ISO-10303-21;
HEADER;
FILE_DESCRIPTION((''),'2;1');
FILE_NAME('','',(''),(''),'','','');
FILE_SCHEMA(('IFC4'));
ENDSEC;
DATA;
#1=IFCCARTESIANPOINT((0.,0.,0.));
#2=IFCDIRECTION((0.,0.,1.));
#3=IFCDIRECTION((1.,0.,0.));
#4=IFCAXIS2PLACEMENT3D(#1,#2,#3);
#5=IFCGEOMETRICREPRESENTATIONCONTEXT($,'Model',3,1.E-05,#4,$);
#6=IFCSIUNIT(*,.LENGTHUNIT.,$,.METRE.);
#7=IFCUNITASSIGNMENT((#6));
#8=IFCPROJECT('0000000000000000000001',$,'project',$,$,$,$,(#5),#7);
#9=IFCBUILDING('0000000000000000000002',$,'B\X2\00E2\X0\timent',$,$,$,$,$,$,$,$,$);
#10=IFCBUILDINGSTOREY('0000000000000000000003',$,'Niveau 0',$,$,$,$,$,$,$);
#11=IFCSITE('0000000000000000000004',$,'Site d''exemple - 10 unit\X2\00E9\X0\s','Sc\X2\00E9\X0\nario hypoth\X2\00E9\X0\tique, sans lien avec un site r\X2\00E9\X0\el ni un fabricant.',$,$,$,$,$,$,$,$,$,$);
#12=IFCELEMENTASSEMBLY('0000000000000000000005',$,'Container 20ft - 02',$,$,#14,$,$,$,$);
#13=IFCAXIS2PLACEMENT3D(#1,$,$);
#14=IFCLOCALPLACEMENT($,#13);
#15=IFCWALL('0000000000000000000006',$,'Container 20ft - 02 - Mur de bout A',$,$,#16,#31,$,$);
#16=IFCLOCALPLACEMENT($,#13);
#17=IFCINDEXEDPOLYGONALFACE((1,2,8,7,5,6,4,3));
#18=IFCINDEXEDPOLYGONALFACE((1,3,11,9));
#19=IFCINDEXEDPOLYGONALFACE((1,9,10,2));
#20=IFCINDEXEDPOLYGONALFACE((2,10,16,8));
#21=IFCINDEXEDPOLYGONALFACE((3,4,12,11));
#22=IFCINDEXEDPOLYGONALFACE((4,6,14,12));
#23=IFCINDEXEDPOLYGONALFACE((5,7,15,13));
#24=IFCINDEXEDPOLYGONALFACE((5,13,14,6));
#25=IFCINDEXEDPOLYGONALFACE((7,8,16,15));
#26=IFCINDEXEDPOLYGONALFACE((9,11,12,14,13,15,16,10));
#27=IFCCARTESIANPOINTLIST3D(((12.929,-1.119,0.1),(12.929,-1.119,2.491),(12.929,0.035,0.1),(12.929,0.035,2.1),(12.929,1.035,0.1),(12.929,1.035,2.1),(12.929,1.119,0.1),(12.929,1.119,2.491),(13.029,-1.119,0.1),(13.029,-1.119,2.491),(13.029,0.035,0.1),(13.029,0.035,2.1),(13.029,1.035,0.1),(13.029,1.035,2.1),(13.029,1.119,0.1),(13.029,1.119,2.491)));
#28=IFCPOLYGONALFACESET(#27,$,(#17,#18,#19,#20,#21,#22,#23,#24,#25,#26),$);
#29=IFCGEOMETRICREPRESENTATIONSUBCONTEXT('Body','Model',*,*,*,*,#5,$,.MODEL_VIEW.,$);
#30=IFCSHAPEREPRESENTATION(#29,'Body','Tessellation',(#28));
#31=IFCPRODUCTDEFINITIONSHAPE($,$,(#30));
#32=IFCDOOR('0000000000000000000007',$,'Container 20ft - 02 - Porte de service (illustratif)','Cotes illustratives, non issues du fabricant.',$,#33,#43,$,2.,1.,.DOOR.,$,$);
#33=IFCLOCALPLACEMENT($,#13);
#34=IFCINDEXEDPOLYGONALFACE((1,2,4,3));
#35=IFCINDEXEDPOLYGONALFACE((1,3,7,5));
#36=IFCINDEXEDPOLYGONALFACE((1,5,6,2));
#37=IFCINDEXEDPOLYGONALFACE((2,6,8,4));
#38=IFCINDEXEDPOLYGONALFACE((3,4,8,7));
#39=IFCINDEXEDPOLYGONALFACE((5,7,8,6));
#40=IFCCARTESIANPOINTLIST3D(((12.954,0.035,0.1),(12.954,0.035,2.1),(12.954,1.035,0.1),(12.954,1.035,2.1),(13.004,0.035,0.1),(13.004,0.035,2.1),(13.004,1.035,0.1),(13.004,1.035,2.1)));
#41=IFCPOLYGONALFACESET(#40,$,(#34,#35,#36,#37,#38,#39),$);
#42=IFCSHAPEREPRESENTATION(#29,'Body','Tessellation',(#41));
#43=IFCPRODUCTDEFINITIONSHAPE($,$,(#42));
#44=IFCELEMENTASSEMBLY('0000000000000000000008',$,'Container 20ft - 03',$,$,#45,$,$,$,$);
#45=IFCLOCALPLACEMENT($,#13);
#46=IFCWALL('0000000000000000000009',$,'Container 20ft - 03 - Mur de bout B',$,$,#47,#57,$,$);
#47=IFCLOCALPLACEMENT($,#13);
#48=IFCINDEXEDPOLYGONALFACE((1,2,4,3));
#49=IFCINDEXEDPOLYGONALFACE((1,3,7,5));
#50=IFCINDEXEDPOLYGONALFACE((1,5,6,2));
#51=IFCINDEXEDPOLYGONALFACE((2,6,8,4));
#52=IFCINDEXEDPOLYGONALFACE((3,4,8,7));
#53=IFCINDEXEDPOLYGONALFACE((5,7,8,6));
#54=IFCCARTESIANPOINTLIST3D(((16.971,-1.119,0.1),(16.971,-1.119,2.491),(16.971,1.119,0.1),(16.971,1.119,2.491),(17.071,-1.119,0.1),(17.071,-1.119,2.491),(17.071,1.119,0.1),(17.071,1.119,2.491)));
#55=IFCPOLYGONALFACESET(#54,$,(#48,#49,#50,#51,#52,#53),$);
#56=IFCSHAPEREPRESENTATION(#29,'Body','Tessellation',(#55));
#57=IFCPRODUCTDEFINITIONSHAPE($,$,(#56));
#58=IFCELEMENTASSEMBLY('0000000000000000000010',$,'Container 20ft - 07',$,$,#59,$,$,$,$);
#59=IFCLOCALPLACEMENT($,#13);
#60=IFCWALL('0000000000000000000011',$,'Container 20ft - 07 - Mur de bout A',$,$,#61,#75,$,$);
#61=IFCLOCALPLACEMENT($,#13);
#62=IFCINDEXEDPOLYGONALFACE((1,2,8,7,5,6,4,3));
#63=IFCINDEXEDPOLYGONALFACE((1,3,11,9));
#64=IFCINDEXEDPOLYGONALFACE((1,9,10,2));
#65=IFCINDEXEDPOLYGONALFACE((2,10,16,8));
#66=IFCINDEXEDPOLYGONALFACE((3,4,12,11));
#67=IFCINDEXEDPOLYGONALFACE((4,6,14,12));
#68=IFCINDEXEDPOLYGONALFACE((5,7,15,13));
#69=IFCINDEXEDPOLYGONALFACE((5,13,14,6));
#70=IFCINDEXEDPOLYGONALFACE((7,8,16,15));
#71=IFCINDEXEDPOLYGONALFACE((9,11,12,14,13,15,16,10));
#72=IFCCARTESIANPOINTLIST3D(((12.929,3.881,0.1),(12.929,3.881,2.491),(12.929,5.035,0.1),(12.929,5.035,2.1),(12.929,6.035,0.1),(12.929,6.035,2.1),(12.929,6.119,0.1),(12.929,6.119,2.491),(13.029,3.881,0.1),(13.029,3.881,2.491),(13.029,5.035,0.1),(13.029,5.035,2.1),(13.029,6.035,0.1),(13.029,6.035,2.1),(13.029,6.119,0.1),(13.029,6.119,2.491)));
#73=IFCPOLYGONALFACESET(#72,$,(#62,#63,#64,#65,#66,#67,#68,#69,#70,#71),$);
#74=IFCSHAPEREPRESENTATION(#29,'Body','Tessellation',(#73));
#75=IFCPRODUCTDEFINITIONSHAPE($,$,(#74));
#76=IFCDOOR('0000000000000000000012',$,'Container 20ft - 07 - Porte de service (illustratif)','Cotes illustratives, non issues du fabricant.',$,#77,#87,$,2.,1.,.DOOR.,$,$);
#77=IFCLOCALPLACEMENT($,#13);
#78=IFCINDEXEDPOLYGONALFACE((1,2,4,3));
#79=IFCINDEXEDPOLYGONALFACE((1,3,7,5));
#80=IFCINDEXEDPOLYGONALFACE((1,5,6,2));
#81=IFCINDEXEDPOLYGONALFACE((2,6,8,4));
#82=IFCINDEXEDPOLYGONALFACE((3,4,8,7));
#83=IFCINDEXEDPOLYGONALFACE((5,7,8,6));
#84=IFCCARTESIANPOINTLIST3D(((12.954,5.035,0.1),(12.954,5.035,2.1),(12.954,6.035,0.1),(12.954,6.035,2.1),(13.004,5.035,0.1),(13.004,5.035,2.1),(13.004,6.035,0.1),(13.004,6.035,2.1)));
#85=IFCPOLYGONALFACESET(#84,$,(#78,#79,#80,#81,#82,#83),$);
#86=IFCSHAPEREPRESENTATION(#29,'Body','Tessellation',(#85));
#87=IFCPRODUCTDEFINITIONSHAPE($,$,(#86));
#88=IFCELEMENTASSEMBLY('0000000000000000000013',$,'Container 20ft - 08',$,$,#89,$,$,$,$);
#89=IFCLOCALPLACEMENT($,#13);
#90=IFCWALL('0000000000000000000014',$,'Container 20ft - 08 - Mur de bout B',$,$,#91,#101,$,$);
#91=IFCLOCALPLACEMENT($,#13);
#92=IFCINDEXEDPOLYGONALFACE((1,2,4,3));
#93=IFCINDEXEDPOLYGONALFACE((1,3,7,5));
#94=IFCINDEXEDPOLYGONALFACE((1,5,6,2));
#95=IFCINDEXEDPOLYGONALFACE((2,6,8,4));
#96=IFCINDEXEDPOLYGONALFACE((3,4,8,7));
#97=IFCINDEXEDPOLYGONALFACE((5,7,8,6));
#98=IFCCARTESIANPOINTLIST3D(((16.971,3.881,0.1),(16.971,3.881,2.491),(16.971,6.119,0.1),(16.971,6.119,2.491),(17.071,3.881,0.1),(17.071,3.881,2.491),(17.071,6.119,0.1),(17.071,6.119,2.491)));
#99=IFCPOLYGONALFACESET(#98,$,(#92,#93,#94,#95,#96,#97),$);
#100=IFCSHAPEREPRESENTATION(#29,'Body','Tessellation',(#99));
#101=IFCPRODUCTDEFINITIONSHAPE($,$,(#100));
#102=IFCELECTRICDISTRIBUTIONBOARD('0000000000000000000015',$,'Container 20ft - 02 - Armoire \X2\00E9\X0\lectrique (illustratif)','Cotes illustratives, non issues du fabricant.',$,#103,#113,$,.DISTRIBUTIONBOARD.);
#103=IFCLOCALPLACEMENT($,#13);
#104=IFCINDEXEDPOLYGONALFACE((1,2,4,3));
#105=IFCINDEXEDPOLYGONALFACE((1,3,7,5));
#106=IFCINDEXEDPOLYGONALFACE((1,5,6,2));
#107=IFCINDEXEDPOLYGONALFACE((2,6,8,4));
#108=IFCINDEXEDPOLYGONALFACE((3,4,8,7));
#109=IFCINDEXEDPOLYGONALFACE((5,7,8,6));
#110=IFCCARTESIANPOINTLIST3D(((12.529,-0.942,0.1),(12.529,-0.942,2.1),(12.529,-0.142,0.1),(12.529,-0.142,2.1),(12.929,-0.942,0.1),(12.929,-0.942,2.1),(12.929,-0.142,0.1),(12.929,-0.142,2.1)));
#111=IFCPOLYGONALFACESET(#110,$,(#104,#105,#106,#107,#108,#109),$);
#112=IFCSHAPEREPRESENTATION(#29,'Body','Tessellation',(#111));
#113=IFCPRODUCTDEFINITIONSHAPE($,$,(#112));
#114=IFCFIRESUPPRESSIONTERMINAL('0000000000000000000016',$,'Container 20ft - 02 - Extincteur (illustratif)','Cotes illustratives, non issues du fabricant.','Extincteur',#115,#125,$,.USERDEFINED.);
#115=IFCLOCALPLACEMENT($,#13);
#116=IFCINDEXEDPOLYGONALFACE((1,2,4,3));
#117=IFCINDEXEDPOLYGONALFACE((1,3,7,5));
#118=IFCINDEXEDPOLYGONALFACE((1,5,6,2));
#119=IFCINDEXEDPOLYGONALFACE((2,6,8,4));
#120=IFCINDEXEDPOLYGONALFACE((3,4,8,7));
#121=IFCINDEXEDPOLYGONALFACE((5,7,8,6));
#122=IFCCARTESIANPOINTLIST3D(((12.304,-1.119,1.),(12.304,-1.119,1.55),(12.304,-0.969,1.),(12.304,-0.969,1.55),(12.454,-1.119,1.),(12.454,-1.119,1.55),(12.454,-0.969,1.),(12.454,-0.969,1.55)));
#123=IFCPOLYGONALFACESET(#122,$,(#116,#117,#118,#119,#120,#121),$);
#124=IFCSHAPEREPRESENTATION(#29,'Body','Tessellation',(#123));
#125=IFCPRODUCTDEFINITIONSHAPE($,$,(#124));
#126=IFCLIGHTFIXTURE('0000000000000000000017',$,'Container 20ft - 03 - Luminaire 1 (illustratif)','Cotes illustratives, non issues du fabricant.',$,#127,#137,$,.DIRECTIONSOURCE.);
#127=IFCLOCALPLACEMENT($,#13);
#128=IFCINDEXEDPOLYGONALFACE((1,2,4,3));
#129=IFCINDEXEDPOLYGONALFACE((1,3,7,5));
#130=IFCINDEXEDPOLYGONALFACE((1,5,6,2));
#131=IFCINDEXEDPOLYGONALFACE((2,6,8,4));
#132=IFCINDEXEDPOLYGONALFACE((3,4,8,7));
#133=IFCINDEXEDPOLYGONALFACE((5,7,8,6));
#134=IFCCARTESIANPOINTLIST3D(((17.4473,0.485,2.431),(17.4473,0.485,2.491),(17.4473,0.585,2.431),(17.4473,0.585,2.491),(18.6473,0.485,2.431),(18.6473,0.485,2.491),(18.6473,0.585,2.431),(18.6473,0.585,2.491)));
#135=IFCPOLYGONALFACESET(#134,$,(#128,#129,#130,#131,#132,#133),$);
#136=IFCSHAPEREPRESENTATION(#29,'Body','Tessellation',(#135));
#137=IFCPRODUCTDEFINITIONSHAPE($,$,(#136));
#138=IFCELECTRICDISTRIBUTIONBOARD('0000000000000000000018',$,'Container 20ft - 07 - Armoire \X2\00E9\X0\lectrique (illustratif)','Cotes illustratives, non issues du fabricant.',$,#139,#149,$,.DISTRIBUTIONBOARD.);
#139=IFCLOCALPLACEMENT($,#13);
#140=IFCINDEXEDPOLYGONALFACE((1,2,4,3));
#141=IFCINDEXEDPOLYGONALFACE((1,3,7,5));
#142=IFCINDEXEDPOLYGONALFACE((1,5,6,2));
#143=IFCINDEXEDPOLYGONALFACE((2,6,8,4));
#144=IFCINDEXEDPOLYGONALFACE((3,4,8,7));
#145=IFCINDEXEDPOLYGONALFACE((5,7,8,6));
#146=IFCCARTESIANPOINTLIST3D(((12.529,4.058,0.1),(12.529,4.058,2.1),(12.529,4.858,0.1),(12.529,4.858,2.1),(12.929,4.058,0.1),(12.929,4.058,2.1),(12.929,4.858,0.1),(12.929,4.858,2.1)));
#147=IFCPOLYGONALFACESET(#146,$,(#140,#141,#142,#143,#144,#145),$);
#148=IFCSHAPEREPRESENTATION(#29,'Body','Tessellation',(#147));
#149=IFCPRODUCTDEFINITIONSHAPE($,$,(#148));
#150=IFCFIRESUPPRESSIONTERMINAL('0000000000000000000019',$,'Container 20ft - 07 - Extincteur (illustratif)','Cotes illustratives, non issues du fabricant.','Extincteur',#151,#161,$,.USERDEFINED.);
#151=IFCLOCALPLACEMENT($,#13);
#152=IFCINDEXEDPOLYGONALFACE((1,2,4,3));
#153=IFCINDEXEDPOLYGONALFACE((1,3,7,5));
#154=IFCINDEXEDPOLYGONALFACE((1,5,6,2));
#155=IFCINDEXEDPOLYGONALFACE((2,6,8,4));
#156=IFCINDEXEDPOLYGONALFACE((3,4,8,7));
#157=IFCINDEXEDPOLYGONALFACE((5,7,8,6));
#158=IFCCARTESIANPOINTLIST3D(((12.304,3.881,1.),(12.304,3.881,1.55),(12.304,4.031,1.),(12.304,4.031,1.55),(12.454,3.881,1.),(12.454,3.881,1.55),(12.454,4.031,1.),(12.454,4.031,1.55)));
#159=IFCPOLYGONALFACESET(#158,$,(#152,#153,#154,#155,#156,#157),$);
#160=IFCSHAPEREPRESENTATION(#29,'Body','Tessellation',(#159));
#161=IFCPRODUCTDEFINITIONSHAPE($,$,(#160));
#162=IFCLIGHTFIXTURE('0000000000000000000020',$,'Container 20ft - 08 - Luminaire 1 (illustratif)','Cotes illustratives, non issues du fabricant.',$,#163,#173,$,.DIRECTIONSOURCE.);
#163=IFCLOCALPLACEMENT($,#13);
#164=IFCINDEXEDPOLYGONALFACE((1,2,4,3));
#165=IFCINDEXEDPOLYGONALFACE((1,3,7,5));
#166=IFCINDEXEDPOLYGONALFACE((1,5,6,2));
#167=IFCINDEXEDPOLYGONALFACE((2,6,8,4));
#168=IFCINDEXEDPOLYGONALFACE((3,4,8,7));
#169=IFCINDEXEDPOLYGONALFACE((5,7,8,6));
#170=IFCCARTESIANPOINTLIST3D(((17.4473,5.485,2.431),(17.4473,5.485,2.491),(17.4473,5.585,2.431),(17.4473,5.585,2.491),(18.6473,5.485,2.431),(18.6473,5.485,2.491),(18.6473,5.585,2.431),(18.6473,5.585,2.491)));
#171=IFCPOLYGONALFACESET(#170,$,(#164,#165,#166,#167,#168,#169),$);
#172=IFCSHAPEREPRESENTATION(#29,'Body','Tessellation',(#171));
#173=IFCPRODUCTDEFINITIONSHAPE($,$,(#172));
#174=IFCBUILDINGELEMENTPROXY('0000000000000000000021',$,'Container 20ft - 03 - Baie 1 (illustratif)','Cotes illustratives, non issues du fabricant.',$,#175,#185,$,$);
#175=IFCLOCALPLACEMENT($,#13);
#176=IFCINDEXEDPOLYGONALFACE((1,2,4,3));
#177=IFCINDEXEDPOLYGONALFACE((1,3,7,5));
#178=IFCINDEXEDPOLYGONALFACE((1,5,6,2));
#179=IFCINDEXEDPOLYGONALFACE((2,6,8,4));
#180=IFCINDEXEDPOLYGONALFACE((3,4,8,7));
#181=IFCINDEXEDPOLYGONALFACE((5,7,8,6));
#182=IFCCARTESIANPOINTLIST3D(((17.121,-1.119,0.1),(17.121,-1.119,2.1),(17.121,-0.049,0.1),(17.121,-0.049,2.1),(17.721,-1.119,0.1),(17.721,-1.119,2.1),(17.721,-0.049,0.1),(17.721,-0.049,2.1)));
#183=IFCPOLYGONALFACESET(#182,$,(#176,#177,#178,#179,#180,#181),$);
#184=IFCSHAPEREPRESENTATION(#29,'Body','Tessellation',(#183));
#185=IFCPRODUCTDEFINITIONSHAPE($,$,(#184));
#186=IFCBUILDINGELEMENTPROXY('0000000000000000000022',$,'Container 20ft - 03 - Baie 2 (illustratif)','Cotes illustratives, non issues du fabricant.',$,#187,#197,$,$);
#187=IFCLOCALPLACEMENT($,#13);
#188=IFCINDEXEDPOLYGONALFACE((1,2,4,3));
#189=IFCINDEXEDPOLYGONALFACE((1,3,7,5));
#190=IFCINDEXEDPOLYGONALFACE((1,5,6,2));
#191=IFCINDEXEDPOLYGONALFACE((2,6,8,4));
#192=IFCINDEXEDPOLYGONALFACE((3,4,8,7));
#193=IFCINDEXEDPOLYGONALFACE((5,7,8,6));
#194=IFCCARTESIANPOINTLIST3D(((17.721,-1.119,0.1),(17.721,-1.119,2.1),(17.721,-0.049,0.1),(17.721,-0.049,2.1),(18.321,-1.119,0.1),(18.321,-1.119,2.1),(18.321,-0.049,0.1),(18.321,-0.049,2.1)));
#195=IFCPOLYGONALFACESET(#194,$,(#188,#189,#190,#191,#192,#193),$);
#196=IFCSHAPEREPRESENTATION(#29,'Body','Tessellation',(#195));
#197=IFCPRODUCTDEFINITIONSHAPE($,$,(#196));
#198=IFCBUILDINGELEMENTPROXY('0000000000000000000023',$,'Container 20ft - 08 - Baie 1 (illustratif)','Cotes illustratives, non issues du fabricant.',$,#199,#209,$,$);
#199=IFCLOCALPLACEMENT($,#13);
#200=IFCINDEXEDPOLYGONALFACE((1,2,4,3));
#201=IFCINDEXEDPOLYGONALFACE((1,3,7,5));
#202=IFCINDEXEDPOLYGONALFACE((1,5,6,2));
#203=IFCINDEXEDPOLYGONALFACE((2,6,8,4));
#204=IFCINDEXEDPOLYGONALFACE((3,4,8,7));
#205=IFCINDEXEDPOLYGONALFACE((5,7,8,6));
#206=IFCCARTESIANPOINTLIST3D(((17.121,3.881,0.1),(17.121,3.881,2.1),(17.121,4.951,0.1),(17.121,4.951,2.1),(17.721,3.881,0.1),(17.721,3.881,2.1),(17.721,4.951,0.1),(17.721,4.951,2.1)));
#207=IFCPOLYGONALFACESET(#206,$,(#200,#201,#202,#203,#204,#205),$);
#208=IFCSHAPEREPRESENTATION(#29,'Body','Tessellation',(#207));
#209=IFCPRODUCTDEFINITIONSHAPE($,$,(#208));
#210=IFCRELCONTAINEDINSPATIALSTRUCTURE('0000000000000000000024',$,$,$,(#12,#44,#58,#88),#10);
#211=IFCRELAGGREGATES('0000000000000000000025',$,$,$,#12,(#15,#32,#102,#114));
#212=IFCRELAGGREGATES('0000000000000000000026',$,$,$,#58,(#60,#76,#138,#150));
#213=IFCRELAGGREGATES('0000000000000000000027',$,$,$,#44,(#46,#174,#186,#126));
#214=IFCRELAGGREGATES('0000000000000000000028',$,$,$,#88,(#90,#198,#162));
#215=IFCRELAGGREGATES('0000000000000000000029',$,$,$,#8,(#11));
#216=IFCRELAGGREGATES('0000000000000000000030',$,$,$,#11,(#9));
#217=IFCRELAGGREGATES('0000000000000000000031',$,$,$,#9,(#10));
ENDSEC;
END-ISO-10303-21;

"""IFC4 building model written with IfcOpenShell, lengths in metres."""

from ifc_helpers import new_model, si_unit, frame, origin_with_axes, place, context, subcontext, project, spatial, rectangle, extrude, element, fill, aggregate, save


model = new_model("IFC4")

# Units and contexts
model_context = context("Model", 3, precision=1e-05, world=origin_with_axes())
body_context = subcontext(model_context, "Body", "Model", "MODEL_VIEW")
ifc_project = project(units=[si_unit("LENGTHUNIT", "METRE")], contexts=[model_context])

# Site, building, storey
site = spatial("IfcSite", under=ifc_project, Name="Site d'exemple - 10 unités", Description="Scénario hypothétique, sans lien avec un site réel ni un fabricant.")
building = spatial("IfcBuilding", under=site, Name="Bâtiment")
storey = spatial("IfcBuildingStorey", under=building, Name="Niveau 0")

# Element assembly, wall, opening, door
assembly_1 = element("IfcElementAssembly", 1, inside=storey, Name="Container 20ft - 02")
wall_1_placement = place(None, frame((12.979, 0.0, 0.1), z_axis=(0.0, 0.0, 1.0), x_axis=(1.0, 0.0, 0.0)))
wall_1 = element("IfcWall", 2, at=wall_1_placement, Name="Container 20ft - 02 - Mur de bout A", context=body_context, shape_type="SweptSolid", body=[
    extrude(rectangle(XDim=0.1, YDim=2.238), origin_with_axes(), (0.0, 0.0, 1.0), 2.391),
])
opening_1_placement = place(None, frame((12.979, 0.535, 0.1), z_axis=(0.0, 0.0, 1.0), x_axis=(1.0, 0.0, 0.0)))
opening_1 = element("IfcOpeningElement", 3, at=opening_1_placement, cuts=wall_1, PredefinedType="OPENING", context=body_context, shape_type="SweptSolid", body=[
    extrude(rectangle(XDim=0.2, YDim=1.0), origin_with_axes(), (0.0, 0.0, 1.0), 2.0),
])
door_1_placement = place(None, frame((12.979, 0.535, 0.1), z_axis=(0.0, 0.0, 1.0), x_axis=(1.0, 0.0, 0.0)))
door_1 = element("IfcDoor", 4, at=door_1_placement, Name="Container 20ft - 02 - Porte de service (illustratif)", Description="Cotes illustratives, non issues du fabricant.", OverallHeight=2.0, OverallWidth=1.0, PredefinedType="DOOR", context=body_context, shape_type="SweptSolid", body=[
    extrude(rectangle(XDim=0.05, YDim=1.0), origin_with_axes(), (0.0, 0.0, 1.0), 2.0),
])
fill(opening_1, door_1)

# Element assembly, wall
assembly_2 = element("IfcElementAssembly", 5, inside=storey, Name="Container 20ft - 03")
wall_2_placement = place(None, frame((17.021, 0.0, 0.1), z_axis=(0.0, 0.0, 1.0), x_axis=(1.0, 0.0, 0.0)))
wall_2 = element("IfcWall", 6, at=wall_2_placement, Name="Container 20ft - 03 - Mur de bout B", context=body_context, shape_type="SweptSolid", body=[
    extrude(rectangle(XDim=0.1, YDim=2.238), origin_with_axes(), (0.0, 0.0, 1.0), 2.391),
])

# Element assembly, wall, opening, door
assembly_3 = element("IfcElementAssembly", 7, inside=storey, Name="Container 20ft - 07")
wall_3_placement = place(None, frame((12.979, 5.0, 0.1), z_axis=(0.0, 0.0, 1.0), x_axis=(1.0, 0.0, 0.0)))
wall_3 = element("IfcWall", 8, at=wall_3_placement, Name="Container 20ft - 07 - Mur de bout A", context=body_context, shape_type="SweptSolid", body=[
    extrude(rectangle(XDim=0.1, YDim=2.238), origin_with_axes(), (0.0, 0.0, 1.0), 2.391),
])
opening_2_placement = place(None, frame((12.979, 5.535, 0.1), z_axis=(0.0, 0.0, 1.0), x_axis=(1.0, 0.0, 0.0)))
opening_2 = element("IfcOpeningElement", 9, at=opening_2_placement, cuts=wall_3, PredefinedType="OPENING", context=body_context, shape_type="SweptSolid", body=[
    extrude(rectangle(XDim=0.2, YDim=1.0), origin_with_axes(), (0.0, 0.0, 1.0), 2.0),
])
door_2_placement = place(None, frame((12.979, 5.535, 0.1), z_axis=(0.0, 0.0, 1.0), x_axis=(1.0, 0.0, 0.0)))
door_2 = element("IfcDoor", 10, at=door_2_placement, Name="Container 20ft - 07 - Porte de service (illustratif)", Description="Cotes illustratives, non issues du fabricant.", OverallHeight=2.0, OverallWidth=1.0, PredefinedType="DOOR", context=body_context, shape_type="SweptSolid", body=[
    extrude(rectangle(XDim=0.05, YDim=1.0), origin_with_axes(), (0.0, 0.0, 1.0), 2.0),
])
fill(opening_2, door_2)

# Element assembly, wall
assembly_4 = element("IfcElementAssembly", 11, inside=storey, Name="Container 20ft - 08")
wall_4_placement = place(None, frame((17.021, 5.0, 0.1), z_axis=(0.0, 0.0, 1.0), x_axis=(1.0, 0.0, 0.0)))
wall_4 = element("IfcWall", 12, at=wall_4_placement, Name="Container 20ft - 08 - Mur de bout B", context=body_context, shape_type="SweptSolid", body=[
    extrude(rectangle(XDim=0.1, YDim=2.238), origin_with_axes(), (0.0, 0.0, 1.0), 2.391),
])

# Electric distribution board
electric_distribution_board_1_placement = place(None, frame((12.729, -0.542, 0.1), z_axis=(0.0, 0.0, 1.0), x_axis=(1.0, 0.0, 0.0)))
electric_distribution_board_1 = element("IfcElectricDistributionBoard", 13, at=electric_distribution_board_1_placement, Name="Container 20ft - 02 - Armoire électrique (illustratif)", Description="Cotes illustratives, non issues du fabricant.", PredefinedType="DISTRIBUTIONBOARD", context=body_context, shape_type="SweptSolid", body=[
    extrude(rectangle(XDim=0.4, YDim=0.8), origin_with_axes(), (0.0, 0.0, 1.0), 2.0),
])

# Fire suppression terminal
fire_suppression_terminal_1_placement = place(None, frame((12.379, -1.044, 1.0), z_axis=(0.0, 0.0, 1.0), x_axis=(1.0, 0.0, 0.0)))
fire_suppression_terminal_1 = element("IfcFireSuppressionTerminal", 14, at=fire_suppression_terminal_1_placement, Name="Container 20ft - 02 - Extincteur (illustratif)", Description="Cotes illustratives, non issues du fabricant.", ObjectType="Extincteur", PredefinedType="USERDEFINED", context=body_context, shape_type="SweptSolid", body=[
    extrude(rectangle(XDim=0.15, YDim=0.15), origin_with_axes(), (0.0, 0.0, 1.0), 0.55),
])
aggregate(assembly_1, [wall_1, door_1, electric_distribution_board_1, fire_suppression_terminal_1])

# Light fixture
light_fixture_1_placement = place(None, frame((18.0473, 0.535, 2.431), z_axis=(0.0, 0.0, 1.0), x_axis=(1.0, 0.0, 0.0)))
light_fixture_1 = element("IfcLightFixture", 15, at=light_fixture_1_placement, Name="Container 20ft - 03 - Luminaire 1 (illustratif)", Description="Cotes illustratives, non issues du fabricant.", PredefinedType="DIRECTIONSOURCE", context=body_context, shape_type="SweptSolid", body=[
    extrude(rectangle(XDim=1.2, YDim=0.1), origin_with_axes(), (0.0, 0.0, 1.0), 0.06),
])

# Electric distribution board
electric_distribution_board_2_placement = place(None, frame((12.729, 4.458, 0.1), z_axis=(0.0, 0.0, 1.0), x_axis=(1.0, 0.0, 0.0)))
electric_distribution_board_2 = element("IfcElectricDistributionBoard", 16, at=electric_distribution_board_2_placement, Name="Container 20ft - 07 - Armoire électrique (illustratif)", Description="Cotes illustratives, non issues du fabricant.", PredefinedType="DISTRIBUTIONBOARD", context=body_context, shape_type="SweptSolid", body=[
    extrude(rectangle(XDim=0.4, YDim=0.8), origin_with_axes(), (0.0, 0.0, 1.0), 2.0),
])

# Fire suppression terminal
fire_suppression_terminal_2_placement = place(None, frame((12.379, 3.956, 1.0), z_axis=(0.0, 0.0, 1.0), x_axis=(1.0, 0.0, 0.0)))
fire_suppression_terminal_2 = element("IfcFireSuppressionTerminal", 17, at=fire_suppression_terminal_2_placement, Name="Container 20ft - 07 - Extincteur (illustratif)", Description="Cotes illustratives, non issues du fabricant.", ObjectType="Extincteur", PredefinedType="USERDEFINED", context=body_context, shape_type="SweptSolid", body=[
    extrude(rectangle(XDim=0.15, YDim=0.15), origin_with_axes(), (0.0, 0.0, 1.0), 0.55),
])
aggregate(assembly_3, [wall_3, door_2, electric_distribution_board_2, fire_suppression_terminal_2])

# Light fixture
light_fixture_2_placement = place(None, frame((18.0473, 5.535, 2.431), z_axis=(0.0, 0.0, 1.0), x_axis=(1.0, 0.0, 0.0)))
light_fixture_2 = element("IfcLightFixture", 18, at=light_fixture_2_placement, Name="Container 20ft - 08 - Luminaire 1 (illustratif)", Description="Cotes illustratives, non issues du fabricant.", PredefinedType="DIRECTIONSOURCE", context=body_context, shape_type="SweptSolid", body=[
    extrude(rectangle(XDim=1.2, YDim=0.1), origin_with_axes(), (0.0, 0.0, 1.0), 0.06),
])

# Building element proxies
proxy_1_placement = place(None, frame((17.421, -0.584, 0.1), z_axis=(0.0, 0.0, 1.0), x_axis=(1.0, 0.0, 0.0)))
proxy_1 = element("IfcBuildingElementProxy", 19, at=proxy_1_placement, Name="Container 20ft - 03 - Baie 1 (illustratif)", Description="Cotes illustratives, non issues du fabricant.", context=body_context, shape_type="SweptSolid", body=[
    extrude(rectangle(XDim=0.6, YDim=1.07), origin_with_axes(), (0.0, 0.0, 1.0), 2.0),
])
proxy_2_placement = place(None, frame((18.021, -0.584, 0.1), z_axis=(0.0, 0.0, 1.0), x_axis=(1.0, 0.0, 0.0)))
proxy_2 = element("IfcBuildingElementProxy", 20, at=proxy_2_placement, Name="Container 20ft - 03 - Baie 2 (illustratif)", Description="Cotes illustratives, non issues du fabricant.", context=body_context, shape_type="SweptSolid", body=[
    extrude(rectangle(XDim=0.6, YDim=1.07), origin_with_axes(), (0.0, 0.0, 1.0), 2.0),
])
aggregate(assembly_2, [wall_2, proxy_1, proxy_2, light_fixture_1])
proxy_3_placement = place(None, frame((17.421, 4.416, 0.1), z_axis=(0.0, 0.0, 1.0), x_axis=(1.0, 0.0, 0.0)))
proxy_3 = element("IfcBuildingElementProxy", 21, at=proxy_3_placement, Name="Container 20ft - 08 - Baie 1 (illustratif)", Description="Cotes illustratives, non issues du fabricant.", context=body_context, shape_type="SweptSolid", body=[
    extrude(rectangle(XDim=0.6, YDim=1.07), origin_with_axes(), (0.0, 0.0, 1.0), 2.0),
])
aggregate(assembly_4, [wall_4, proxy_3, light_fixture_2])

save(model, "model.ifc")
